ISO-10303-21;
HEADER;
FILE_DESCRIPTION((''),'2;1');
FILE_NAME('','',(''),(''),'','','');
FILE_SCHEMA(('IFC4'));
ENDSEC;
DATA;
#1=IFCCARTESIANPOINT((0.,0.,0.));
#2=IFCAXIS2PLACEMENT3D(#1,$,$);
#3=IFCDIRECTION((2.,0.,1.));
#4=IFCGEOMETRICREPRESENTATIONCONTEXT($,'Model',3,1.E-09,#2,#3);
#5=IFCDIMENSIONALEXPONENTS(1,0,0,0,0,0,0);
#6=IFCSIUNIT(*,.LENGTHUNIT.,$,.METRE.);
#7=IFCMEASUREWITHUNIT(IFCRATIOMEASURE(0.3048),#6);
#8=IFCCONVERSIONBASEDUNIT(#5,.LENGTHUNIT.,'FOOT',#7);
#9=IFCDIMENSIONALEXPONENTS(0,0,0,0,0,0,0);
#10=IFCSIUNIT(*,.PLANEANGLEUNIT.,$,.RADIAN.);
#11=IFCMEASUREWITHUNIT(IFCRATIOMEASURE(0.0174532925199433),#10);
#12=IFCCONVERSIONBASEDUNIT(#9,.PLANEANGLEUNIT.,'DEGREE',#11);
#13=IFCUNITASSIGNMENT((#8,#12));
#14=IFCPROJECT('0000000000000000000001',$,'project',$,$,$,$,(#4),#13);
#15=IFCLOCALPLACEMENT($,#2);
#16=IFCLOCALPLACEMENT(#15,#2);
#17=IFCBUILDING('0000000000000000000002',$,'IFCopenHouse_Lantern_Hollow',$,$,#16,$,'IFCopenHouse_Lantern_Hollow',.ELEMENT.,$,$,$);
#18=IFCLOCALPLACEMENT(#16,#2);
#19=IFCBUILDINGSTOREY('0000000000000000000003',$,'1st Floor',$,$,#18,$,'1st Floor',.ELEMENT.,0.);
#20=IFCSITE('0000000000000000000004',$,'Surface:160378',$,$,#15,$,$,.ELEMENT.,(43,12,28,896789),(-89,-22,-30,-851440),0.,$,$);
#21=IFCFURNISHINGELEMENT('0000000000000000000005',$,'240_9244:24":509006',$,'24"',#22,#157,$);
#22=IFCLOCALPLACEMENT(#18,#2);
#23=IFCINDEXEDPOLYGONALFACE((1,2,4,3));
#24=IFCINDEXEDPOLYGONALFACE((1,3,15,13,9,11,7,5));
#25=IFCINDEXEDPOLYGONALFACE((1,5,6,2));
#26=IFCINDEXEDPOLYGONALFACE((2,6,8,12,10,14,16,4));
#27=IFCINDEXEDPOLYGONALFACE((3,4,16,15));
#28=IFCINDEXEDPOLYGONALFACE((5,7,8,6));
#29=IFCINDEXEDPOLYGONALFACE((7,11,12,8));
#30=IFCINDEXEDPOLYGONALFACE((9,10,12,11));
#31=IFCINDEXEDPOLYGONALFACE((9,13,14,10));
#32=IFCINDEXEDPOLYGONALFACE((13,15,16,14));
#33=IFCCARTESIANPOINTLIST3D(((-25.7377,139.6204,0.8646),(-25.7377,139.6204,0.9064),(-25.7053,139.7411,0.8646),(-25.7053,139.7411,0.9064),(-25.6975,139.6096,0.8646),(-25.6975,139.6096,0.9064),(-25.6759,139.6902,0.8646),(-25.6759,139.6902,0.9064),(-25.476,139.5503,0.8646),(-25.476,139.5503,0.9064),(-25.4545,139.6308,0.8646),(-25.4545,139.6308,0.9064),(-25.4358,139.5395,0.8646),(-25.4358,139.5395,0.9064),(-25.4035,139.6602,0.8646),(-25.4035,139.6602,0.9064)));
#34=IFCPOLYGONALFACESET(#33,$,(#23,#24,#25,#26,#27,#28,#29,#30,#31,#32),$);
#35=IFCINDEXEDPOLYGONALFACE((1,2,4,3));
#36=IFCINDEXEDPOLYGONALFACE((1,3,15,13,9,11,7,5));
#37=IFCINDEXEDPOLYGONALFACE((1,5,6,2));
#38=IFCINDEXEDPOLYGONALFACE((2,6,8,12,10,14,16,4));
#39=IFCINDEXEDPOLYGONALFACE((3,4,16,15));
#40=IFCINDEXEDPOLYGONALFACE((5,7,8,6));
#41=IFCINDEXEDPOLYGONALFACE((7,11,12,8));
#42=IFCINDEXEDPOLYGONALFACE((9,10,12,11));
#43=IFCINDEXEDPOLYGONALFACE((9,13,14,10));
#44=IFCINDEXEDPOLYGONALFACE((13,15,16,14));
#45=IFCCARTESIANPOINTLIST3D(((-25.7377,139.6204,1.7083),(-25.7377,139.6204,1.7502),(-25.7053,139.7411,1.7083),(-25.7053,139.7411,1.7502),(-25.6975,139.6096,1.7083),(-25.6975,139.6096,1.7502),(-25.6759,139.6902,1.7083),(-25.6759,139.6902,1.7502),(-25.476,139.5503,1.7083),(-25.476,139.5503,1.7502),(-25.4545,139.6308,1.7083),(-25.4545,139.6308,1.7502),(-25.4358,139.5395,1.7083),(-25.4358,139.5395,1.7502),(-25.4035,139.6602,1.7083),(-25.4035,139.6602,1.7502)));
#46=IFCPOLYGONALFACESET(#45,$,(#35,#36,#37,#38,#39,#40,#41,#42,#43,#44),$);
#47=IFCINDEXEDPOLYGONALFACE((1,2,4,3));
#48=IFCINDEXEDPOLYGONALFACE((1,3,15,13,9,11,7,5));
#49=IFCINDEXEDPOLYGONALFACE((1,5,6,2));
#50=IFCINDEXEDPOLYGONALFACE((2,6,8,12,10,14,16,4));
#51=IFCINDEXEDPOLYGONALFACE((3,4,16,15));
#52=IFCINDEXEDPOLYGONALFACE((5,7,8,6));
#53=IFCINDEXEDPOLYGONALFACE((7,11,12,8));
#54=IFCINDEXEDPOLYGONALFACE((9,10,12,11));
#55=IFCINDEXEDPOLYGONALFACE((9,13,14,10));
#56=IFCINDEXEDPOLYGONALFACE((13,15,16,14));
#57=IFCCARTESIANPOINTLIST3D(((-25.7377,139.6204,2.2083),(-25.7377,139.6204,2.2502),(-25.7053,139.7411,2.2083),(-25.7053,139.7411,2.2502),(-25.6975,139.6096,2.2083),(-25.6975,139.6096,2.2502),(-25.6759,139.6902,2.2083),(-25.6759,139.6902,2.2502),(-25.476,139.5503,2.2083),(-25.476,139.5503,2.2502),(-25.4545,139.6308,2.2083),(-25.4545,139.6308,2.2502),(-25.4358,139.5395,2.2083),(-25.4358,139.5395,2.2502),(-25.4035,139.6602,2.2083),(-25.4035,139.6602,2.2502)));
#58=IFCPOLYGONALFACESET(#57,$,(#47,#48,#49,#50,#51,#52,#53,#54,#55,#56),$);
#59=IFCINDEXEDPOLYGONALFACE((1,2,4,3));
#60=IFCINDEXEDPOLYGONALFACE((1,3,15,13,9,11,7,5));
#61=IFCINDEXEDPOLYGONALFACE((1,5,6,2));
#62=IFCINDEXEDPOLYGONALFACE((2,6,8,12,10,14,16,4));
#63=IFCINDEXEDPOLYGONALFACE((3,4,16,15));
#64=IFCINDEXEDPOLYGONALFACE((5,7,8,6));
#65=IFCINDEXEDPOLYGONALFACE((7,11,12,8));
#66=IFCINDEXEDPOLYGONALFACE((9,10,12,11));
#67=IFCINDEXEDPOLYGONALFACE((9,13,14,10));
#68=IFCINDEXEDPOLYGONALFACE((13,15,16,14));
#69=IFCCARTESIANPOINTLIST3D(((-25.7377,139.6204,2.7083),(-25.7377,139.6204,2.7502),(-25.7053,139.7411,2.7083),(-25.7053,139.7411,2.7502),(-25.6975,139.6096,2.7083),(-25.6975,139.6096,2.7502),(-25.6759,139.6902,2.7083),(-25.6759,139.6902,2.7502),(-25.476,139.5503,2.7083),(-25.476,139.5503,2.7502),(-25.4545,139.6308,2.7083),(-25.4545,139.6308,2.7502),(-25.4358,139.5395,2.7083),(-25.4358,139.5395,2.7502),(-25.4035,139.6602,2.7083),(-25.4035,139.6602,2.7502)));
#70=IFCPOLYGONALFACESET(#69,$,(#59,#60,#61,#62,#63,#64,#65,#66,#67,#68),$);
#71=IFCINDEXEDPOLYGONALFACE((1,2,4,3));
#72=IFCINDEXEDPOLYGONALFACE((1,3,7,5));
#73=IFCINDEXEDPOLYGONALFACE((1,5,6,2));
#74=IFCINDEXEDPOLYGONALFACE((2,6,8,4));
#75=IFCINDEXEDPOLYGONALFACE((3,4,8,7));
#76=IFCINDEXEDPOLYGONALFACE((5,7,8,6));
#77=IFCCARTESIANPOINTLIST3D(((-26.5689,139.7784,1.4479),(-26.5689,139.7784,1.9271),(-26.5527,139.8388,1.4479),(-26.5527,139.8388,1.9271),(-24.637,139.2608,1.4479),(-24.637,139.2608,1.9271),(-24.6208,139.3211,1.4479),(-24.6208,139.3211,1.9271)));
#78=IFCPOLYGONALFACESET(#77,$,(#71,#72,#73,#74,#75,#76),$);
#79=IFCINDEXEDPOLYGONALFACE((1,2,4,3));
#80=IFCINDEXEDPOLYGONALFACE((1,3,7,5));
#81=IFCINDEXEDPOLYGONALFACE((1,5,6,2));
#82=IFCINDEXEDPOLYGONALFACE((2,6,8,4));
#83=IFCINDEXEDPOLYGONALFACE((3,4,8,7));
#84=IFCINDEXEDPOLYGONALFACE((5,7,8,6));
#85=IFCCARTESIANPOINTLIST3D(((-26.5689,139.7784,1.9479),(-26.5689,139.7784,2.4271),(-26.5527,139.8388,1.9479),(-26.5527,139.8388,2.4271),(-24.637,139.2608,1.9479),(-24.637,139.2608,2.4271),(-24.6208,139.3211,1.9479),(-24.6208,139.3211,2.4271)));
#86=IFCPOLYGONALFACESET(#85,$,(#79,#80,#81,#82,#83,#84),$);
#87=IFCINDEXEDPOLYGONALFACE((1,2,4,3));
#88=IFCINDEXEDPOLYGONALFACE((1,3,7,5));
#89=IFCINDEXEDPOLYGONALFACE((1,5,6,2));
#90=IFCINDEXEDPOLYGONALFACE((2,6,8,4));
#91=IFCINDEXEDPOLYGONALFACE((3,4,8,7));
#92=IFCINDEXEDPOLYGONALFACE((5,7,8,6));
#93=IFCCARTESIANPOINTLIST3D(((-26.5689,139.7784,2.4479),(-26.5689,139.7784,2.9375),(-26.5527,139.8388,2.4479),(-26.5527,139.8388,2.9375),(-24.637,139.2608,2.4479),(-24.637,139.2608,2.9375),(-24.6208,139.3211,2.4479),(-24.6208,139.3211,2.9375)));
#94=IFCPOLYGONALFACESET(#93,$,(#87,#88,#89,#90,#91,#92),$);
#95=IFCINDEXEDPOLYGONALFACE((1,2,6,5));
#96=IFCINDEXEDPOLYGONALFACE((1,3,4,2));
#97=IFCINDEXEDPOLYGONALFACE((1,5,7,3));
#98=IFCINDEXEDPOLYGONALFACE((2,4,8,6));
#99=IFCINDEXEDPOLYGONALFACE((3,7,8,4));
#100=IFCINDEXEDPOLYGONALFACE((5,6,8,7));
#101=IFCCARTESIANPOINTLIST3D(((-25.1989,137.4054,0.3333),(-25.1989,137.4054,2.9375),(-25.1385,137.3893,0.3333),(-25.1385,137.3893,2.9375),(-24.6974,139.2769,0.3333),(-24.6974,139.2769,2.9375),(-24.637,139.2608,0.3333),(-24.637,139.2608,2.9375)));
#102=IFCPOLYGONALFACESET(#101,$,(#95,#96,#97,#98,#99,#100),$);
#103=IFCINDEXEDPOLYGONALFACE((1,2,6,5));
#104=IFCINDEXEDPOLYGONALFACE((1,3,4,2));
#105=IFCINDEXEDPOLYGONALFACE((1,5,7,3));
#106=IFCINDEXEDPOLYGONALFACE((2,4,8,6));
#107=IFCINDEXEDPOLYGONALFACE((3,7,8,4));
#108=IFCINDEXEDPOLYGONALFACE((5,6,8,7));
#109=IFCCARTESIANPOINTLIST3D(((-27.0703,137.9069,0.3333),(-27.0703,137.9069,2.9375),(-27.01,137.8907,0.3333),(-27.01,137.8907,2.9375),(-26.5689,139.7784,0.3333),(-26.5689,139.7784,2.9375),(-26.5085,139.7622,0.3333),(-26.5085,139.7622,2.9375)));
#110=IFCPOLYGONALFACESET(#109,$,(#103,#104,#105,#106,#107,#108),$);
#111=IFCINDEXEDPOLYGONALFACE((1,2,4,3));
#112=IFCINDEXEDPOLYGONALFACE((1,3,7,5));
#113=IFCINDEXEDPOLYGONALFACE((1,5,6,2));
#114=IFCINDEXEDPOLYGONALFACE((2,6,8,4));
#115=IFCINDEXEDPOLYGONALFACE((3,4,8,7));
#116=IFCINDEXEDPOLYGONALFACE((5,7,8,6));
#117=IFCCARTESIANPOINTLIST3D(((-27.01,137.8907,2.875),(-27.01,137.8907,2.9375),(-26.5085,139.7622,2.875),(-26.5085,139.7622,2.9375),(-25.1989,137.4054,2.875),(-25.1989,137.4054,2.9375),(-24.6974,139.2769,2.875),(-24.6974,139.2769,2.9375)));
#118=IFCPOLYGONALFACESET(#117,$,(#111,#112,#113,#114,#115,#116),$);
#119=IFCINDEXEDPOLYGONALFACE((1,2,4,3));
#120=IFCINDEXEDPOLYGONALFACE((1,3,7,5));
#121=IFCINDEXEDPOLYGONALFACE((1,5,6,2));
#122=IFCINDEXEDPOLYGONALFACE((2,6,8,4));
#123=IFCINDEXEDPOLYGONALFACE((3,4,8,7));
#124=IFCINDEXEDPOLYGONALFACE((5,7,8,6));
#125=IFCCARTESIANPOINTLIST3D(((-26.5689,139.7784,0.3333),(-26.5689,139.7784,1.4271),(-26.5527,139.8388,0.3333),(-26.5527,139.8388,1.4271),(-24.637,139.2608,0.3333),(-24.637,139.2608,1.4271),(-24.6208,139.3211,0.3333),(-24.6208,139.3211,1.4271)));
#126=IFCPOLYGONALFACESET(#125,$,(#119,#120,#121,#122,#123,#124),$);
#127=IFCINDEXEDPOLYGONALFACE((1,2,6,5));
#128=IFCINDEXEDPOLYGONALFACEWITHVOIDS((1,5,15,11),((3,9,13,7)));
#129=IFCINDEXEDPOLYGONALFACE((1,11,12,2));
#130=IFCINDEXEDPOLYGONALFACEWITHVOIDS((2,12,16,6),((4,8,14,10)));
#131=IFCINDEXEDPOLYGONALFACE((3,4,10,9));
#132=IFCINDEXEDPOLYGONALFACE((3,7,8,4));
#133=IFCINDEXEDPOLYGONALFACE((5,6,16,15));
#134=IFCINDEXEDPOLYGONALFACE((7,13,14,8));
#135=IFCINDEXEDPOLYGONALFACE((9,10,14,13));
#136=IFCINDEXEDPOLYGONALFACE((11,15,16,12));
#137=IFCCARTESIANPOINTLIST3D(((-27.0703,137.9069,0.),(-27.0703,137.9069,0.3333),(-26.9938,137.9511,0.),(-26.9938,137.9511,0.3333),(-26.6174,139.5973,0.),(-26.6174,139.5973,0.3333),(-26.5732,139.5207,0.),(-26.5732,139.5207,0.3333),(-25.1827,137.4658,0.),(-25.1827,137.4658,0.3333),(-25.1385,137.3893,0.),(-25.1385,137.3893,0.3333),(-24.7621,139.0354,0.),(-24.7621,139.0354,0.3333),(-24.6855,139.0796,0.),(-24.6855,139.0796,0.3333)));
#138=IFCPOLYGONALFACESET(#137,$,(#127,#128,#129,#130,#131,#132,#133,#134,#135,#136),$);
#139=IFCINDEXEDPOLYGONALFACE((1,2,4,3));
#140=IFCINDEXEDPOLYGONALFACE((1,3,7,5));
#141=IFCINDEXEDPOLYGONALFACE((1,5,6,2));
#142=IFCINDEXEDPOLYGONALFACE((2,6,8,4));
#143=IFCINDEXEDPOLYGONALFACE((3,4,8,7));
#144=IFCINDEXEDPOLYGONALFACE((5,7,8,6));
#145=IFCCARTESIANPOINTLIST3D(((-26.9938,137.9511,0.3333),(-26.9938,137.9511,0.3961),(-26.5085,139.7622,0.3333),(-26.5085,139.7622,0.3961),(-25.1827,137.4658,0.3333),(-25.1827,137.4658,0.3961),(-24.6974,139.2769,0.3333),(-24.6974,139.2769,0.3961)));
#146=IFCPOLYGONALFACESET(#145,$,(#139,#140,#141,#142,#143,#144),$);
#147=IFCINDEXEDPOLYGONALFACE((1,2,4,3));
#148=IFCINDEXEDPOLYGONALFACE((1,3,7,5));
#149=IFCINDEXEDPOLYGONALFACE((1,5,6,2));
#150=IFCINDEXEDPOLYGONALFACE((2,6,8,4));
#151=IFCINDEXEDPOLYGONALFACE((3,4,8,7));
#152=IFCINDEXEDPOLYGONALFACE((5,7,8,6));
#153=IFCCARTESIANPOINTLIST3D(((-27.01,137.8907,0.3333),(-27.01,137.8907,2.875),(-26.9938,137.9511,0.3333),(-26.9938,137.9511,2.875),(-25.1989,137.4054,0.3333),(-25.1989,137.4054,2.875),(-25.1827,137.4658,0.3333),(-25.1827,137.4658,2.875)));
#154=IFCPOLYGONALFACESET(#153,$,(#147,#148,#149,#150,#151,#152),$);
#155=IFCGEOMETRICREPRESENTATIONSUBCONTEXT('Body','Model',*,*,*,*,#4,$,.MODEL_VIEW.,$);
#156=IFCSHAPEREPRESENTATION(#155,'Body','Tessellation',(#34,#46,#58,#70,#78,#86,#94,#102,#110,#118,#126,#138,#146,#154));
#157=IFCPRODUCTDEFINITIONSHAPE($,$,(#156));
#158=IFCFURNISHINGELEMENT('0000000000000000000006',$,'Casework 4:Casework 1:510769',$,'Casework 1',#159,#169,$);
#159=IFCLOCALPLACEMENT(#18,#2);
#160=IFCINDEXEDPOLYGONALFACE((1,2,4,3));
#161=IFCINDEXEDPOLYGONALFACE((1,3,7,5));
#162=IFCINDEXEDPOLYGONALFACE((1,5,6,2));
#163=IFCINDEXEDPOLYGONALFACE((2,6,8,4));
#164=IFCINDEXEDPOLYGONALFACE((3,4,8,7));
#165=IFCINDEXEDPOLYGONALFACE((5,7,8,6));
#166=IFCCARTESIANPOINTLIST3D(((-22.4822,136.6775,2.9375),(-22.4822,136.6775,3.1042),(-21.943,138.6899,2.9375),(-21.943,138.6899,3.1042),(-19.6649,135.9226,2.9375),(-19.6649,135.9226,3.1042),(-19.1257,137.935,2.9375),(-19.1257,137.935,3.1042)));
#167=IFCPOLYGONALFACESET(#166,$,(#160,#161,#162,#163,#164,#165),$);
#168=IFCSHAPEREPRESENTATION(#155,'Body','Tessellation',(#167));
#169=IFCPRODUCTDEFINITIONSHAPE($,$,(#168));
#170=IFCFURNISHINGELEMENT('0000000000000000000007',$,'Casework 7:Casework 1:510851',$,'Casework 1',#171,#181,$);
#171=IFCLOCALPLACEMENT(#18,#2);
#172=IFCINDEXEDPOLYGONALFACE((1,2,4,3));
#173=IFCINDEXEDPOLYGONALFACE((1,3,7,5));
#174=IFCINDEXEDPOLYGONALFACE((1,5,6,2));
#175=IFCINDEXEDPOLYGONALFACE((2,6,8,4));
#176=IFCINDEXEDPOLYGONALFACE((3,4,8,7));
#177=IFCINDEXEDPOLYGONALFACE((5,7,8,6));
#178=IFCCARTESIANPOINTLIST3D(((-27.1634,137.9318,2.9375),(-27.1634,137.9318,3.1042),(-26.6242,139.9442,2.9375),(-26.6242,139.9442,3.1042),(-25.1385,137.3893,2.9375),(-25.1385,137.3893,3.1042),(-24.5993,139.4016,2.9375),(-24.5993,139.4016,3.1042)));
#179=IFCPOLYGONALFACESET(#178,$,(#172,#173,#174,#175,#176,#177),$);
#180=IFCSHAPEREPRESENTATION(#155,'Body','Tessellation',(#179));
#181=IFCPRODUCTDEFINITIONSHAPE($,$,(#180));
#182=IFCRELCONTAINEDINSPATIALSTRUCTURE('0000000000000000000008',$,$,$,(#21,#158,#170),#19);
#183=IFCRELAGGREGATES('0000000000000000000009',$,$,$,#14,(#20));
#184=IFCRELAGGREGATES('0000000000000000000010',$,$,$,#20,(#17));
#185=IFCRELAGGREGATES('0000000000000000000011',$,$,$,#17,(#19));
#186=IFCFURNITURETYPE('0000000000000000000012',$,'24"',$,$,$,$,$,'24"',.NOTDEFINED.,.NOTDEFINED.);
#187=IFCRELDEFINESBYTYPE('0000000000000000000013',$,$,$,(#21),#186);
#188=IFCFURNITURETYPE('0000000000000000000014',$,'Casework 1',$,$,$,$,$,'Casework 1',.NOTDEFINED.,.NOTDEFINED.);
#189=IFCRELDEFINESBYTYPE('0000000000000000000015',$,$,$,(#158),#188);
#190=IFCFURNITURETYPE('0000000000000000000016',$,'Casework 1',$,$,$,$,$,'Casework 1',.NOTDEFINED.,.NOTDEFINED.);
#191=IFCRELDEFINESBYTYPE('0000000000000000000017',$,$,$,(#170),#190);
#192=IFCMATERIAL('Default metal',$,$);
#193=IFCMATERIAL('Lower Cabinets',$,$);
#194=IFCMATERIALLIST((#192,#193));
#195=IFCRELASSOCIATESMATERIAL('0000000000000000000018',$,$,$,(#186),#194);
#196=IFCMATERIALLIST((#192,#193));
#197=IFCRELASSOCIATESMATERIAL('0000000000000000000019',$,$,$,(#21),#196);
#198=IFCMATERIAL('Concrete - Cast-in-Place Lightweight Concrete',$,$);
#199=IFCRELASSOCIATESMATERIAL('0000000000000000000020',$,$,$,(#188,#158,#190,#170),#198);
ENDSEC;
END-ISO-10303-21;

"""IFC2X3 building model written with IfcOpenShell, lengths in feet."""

from ifc_helpers import new_model, entity, si_unit, converted_unit, direction, frame, frame_2d, origin, origin_2d_with_axis, place, context, subcontext, project, spatial, polyline, rectangle, outline, extrude, source, transform, mapped, material, material_list, type_object, type_shapes, element, save


model = new_model("IFC2X3")

# Units and contexts
model_context = context("Model", 3, precision=1e-09, world=origin(), true_north=direction((2.0, 0.0, 1.0)))
body_context = subcontext(model_context, "Body", "Model", "MODEL_VIEW")
ifc_project = project(units=[converted_unit("LENGTHUNIT", "FOOT", entity("IfcRatioMeasure", 0.3048), si_unit("LENGTHUNIT", "METRE"), dimensions=[1, 0, 0, 0, 0, 0, 0]), converted_unit("PLANEANGLEUNIT", "DEGREE", entity("IfcRatioMeasure", 0.0174532925199433), si_unit("PLANEANGLEUNIT", "RADIAN"), dimensions=[0, 0, 0, 0, 0, 0, 0])], contexts=[model_context])

# Site, building, storey
site_placement = place(None, origin())
site = spatial("IfcSite", under=ifc_project, at=site_placement, Name="Surface:160378", CompositionType="ELEMENT", RefLatitude=(43, 12, 28, 896789), RefLongitude=(-89, -22, -30, -851440), RefElevation=0.0)
building_placement = place(site_placement, origin())
building = spatial("IfcBuilding", under=site, at=building_placement, Name="IFCopenHouse_Lantern_Hollow", LongName="IFCopenHouse_Lantern_Hollow", CompositionType="ELEMENT")
storey_placement = place(building_placement, origin())
storey = spatial("IfcBuildingStorey", under=building, at=storey_placement, Name="1st Floor", LongName="1st Floor", CompositionType="ELEMENT", Elevation=0.0)

# Furnishing elements
ifc_material_1 = material(Name="Default metal")
ifc_material_2 = material(Name="Lower Cabinets")
ifc_material_3 = material(Name="Concrete - Cast-in-Place Lightweight Concrete")
ifc_material_list_1 = material_list([ifc_material_1, ifc_material_2])
ifc_material_list_2 = material_list([ifc_material_1, ifc_material_2])
furniture_type_1 = type_object("IfcFurnitureType", Name="24\"", ElementType="24\"", AssemblyPlace="NOTDEFINED", material=ifc_material_list_2)
shared_shape_1 = source(origin(), body_context, "Body", "SweptSolid", [
    extrude(outline(polyline([(-0.0521, -0.1562), (0.0729, -0.1562), (0.0729, 0.1562), (-0.0521, 0.1562), (-0.0521, 0.1146), (0.0313, 0.1146), (0.0313, -0.1146), (-0.0521, -0.1146), (-0.0521, -0.1562)])), frame((1.0, 0.0729, 0.8646), z_axis=(0.0, 0.0, 1.0), x_axis=(0.0, -1.0, 0.0)), (0.0, 0.0, 1.0), 0.0418),
    extrude(outline(polyline([(-0.0521, -0.1562), (0.0729, -0.1562), (0.0729, 0.1562), (-0.0521, 0.1562), (-0.0521, 0.1146), (0.0313, 0.1146), (0.0313, -0.1146), (-0.0521, -0.1146), (-0.0521, -0.1562)])), frame((1.0, 0.0729, 1.7083), z_axis=(0.0, 0.0, 1.0), x_axis=(0.0, -1.0, 0.0)), (0.0, 0.0, 1.0), 0.0418),
    extrude(outline(polyline([(-0.0521, -0.1562), (0.0729, -0.1562), (0.0729, 0.1562), (-0.0521, 0.1562), (-0.0521, 0.1146), (0.0313, 0.1146), (0.0313, -0.1146), (-0.0521, -0.1146), (-0.0521, -0.1562)])), frame((1.0, 0.0729, 2.2083), z_axis=(0.0, 0.0, 1.0), x_axis=(0.0, -1.0, 0.0)), (0.0, 0.0, 1.0), 0.0418),
    extrude(outline(polyline([(-0.0521, -0.1562), (0.0729, -0.1562), (0.0729, 0.1562), (-0.0521, 0.1562), (-0.0521, 0.1146), (0.0313, 0.1146), (0.0313, -0.1146), (-0.0521, -0.1146), (-0.0521, -0.1562)])), frame((1.0, 0.0729, 2.7083), z_axis=(0.0, 0.0, 1.0), x_axis=(0.0, -1.0, 0.0)), (0.0, 0.0, 1.0), 0.0418),
    extrude(rectangle(XDim=0.0625, YDim=2.0, at=origin_2d_with_axis()), frame((1.0, 0.1562, 1.4479), z_axis=(0.0, 0.0, 1.0), x_axis=(0.0, 1.0, 0.0)), (0.0, 0.0, 1.0), 0.4792),
    extrude(rectangle(XDim=0.0625, YDim=2.0, at=origin_2d_with_axis()), frame((1.0, 0.1562, 1.9479), z_axis=(0.0, 0.0, 1.0), x_axis=(0.0, 1.0, 0.0)), (0.0, 0.0, 1.0), 0.4792),
    extrude(rectangle(XDim=0.0625, YDim=2.0, at=origin_2d_with_axis()), frame((1.0, 0.1562, 2.4479), z_axis=(0.0, 0.0, 1.0), x_axis=(0.0, 1.0, 0.0)), (0.0, 0.0, 1.0), 0.4896),
    extrude(rectangle(XDim=0.0625, YDim=1.9375, at=frame_2d((0.0, 0.0), x_axis=(1.0, 0.0))), frame((0.0313, 1.1562, 0.3333)), (0.0, 0.0, 1.0), 2.6042),
    extrude(rectangle(XDim=0.0625, YDim=1.9375, at=frame_2d((0.0, 0.0), x_axis=(1.0, 0.0))), frame((1.9688, 1.1562, 0.3333)), (0.0, 0.0, 1.0), 2.6042),
    extrude(rectangle(XDim=1.875, YDim=1.9375, at=frame_2d((0.0, 0.0), x_axis=(1.0, 0.0))), frame((1.0, 1.1562, 2.875), z_axis=(0.0, 0.0, 1.0), x_axis=(-1.0, 0.0, 0.0)), (0.0, 0.0, 1.0), 0.0625),
    extrude(rectangle(XDim=0.0625, YDim=2.0, at=origin_2d_with_axis()), frame((1.0, 0.1562, 0.3333), z_axis=(0.0, 0.0, 1.0), x_axis=(0.0, 1.0, 0.0)), (0.0, 0.0, 1.0), 1.0937),
    extrude(outline(polyline([(-1.0, -0.875), (1.0, -0.875), (1.0, 0.875), (-1.0, 0.875), (-1.0, -0.875)]), holes=[polyline([(-0.9375, -0.8125), (-0.9375, 0.8125), (0.9375, 0.8125), (0.9375, -0.8125), (-0.9375, -0.8125)])]), frame((1.0, 1.25, 0.0)), (0.0, 0.0, 1.0), 0.3333),
    extrude(rectangle(XDim=1.875, YDim=1.875, at=frame_2d((0.0, 0.0), x_axis=(1.0, 0.0))), frame((1.0, 1.125, 0.3333), z_axis=(0.0, 0.0, 1.0), x_axis=(-1.0, 0.0, 0.0)), (0.0, 0.0, 1.0), 0.0627),
    extrude(rectangle(XDim=0.0625, YDim=1.875, at=origin_2d_with_axis()), frame((1.0, 2.0938, 0.3333), z_axis=(0.0, 0.0, 1.0), x_axis=(0.0, 1.0, 0.0)), (0.0, 0.0, 1.0), 2.5417),
])
type_shapes(furniture_type_1, [shared_shape_1])
furnishing_1_placement = place(storey_placement, frame((-24.5885, 139.4419, 0.0), z_axis=(0.0, 0.0, 1.0), x_axis=(-0.965926, 0.258819, 0.0)))
element("IfcFurnishingElement", 1, at=furnishing_1_placement, inside=storey, type_object=furniture_type_1, material=ifc_material_list_1, Name="240_9244:24\":509006", ObjectType="24\"", context=body_context, shape_type="MappedRepresentation", body=[
    mapped(shared_shape_1, transform((0.0, 0.0, 0.0), scale=1.0)),
])
furniture_type_2 = type_object("IfcFurnitureType", Name="Casework 1", ElementType="Casework 1", AssemblyPlace="NOTDEFINED", material=ifc_material_3)
shared_shape_2 = source(origin(), body_context, "Body", "SweptSolid", [
    extrude(rectangle(XDim=2.9167, YDim=2.0833, at=frame_2d((0.0, 0.0), x_axis=(1.0, 0.0))), frame((1.6782, 1.3836, 0.0), z_axis=(0.0, 0.0, 1.0), x_axis=(0.965926, -0.258819, 0.0)), (0.0, 0.0, 1.0), 0.1667),
])
type_shapes(furniture_type_2, [shared_shape_2])
furnishing_2_placement = place(storey_placement, frame((-22.4822, 135.9226, 2.9375)))
element("IfcFurnishingElement", 2, at=furnishing_2_placement, inside=storey, type_object=furniture_type_2, material=ifc_material_3, Name="Casework 4:Casework 1:510769", ObjectType="Casework 1", context=body_context, shape_type="MappedRepresentation", body=[
    mapped(shared_shape_2, transform((0.0, 0.0, 0.0), scale=1.0)),
])
furniture_type_3 = type_object("IfcFurnitureType", Name="Casework 1", ElementType="Casework 1", AssemblyPlace="NOTDEFINED", material=ifc_material_3)
shared_shape_3 = source(origin(), body_context, "Body", "SweptSolid", [
    extrude(rectangle(XDim=2.0964, YDim=2.0833, at=frame_2d((0.0, 0.0), x_axis=(1.0, 0.0))), frame((1.2775, 1.2821, 0.0), z_axis=(0.0, 0.0, 1.0), x_axis=(-0.258819, -0.965926, 0.0)), (0.0, 0.0, 1.0), 0.1667),
])
type_shapes(furniture_type_3, [shared_shape_3])
furnishing_3_placement = place(storey_placement, frame((-24.5993, 137.3893, 2.9375), z_axis=(0.0, 0.0, 1.0), x_axis=(0.0, 1.0, 0.0)))
element("IfcFurnishingElement", 3, at=furnishing_3_placement, inside=storey, type_object=furniture_type_3, material=ifc_material_3, Name="Casework 7:Casework 1:510851", ObjectType="Casework 1", context=body_context, shape_type="MappedRepresentation", body=[
    mapped(shared_shape_3, transform((0.0, 0.0, 0.0), scale=1.0)),
])

save(model, "model.ifc")
